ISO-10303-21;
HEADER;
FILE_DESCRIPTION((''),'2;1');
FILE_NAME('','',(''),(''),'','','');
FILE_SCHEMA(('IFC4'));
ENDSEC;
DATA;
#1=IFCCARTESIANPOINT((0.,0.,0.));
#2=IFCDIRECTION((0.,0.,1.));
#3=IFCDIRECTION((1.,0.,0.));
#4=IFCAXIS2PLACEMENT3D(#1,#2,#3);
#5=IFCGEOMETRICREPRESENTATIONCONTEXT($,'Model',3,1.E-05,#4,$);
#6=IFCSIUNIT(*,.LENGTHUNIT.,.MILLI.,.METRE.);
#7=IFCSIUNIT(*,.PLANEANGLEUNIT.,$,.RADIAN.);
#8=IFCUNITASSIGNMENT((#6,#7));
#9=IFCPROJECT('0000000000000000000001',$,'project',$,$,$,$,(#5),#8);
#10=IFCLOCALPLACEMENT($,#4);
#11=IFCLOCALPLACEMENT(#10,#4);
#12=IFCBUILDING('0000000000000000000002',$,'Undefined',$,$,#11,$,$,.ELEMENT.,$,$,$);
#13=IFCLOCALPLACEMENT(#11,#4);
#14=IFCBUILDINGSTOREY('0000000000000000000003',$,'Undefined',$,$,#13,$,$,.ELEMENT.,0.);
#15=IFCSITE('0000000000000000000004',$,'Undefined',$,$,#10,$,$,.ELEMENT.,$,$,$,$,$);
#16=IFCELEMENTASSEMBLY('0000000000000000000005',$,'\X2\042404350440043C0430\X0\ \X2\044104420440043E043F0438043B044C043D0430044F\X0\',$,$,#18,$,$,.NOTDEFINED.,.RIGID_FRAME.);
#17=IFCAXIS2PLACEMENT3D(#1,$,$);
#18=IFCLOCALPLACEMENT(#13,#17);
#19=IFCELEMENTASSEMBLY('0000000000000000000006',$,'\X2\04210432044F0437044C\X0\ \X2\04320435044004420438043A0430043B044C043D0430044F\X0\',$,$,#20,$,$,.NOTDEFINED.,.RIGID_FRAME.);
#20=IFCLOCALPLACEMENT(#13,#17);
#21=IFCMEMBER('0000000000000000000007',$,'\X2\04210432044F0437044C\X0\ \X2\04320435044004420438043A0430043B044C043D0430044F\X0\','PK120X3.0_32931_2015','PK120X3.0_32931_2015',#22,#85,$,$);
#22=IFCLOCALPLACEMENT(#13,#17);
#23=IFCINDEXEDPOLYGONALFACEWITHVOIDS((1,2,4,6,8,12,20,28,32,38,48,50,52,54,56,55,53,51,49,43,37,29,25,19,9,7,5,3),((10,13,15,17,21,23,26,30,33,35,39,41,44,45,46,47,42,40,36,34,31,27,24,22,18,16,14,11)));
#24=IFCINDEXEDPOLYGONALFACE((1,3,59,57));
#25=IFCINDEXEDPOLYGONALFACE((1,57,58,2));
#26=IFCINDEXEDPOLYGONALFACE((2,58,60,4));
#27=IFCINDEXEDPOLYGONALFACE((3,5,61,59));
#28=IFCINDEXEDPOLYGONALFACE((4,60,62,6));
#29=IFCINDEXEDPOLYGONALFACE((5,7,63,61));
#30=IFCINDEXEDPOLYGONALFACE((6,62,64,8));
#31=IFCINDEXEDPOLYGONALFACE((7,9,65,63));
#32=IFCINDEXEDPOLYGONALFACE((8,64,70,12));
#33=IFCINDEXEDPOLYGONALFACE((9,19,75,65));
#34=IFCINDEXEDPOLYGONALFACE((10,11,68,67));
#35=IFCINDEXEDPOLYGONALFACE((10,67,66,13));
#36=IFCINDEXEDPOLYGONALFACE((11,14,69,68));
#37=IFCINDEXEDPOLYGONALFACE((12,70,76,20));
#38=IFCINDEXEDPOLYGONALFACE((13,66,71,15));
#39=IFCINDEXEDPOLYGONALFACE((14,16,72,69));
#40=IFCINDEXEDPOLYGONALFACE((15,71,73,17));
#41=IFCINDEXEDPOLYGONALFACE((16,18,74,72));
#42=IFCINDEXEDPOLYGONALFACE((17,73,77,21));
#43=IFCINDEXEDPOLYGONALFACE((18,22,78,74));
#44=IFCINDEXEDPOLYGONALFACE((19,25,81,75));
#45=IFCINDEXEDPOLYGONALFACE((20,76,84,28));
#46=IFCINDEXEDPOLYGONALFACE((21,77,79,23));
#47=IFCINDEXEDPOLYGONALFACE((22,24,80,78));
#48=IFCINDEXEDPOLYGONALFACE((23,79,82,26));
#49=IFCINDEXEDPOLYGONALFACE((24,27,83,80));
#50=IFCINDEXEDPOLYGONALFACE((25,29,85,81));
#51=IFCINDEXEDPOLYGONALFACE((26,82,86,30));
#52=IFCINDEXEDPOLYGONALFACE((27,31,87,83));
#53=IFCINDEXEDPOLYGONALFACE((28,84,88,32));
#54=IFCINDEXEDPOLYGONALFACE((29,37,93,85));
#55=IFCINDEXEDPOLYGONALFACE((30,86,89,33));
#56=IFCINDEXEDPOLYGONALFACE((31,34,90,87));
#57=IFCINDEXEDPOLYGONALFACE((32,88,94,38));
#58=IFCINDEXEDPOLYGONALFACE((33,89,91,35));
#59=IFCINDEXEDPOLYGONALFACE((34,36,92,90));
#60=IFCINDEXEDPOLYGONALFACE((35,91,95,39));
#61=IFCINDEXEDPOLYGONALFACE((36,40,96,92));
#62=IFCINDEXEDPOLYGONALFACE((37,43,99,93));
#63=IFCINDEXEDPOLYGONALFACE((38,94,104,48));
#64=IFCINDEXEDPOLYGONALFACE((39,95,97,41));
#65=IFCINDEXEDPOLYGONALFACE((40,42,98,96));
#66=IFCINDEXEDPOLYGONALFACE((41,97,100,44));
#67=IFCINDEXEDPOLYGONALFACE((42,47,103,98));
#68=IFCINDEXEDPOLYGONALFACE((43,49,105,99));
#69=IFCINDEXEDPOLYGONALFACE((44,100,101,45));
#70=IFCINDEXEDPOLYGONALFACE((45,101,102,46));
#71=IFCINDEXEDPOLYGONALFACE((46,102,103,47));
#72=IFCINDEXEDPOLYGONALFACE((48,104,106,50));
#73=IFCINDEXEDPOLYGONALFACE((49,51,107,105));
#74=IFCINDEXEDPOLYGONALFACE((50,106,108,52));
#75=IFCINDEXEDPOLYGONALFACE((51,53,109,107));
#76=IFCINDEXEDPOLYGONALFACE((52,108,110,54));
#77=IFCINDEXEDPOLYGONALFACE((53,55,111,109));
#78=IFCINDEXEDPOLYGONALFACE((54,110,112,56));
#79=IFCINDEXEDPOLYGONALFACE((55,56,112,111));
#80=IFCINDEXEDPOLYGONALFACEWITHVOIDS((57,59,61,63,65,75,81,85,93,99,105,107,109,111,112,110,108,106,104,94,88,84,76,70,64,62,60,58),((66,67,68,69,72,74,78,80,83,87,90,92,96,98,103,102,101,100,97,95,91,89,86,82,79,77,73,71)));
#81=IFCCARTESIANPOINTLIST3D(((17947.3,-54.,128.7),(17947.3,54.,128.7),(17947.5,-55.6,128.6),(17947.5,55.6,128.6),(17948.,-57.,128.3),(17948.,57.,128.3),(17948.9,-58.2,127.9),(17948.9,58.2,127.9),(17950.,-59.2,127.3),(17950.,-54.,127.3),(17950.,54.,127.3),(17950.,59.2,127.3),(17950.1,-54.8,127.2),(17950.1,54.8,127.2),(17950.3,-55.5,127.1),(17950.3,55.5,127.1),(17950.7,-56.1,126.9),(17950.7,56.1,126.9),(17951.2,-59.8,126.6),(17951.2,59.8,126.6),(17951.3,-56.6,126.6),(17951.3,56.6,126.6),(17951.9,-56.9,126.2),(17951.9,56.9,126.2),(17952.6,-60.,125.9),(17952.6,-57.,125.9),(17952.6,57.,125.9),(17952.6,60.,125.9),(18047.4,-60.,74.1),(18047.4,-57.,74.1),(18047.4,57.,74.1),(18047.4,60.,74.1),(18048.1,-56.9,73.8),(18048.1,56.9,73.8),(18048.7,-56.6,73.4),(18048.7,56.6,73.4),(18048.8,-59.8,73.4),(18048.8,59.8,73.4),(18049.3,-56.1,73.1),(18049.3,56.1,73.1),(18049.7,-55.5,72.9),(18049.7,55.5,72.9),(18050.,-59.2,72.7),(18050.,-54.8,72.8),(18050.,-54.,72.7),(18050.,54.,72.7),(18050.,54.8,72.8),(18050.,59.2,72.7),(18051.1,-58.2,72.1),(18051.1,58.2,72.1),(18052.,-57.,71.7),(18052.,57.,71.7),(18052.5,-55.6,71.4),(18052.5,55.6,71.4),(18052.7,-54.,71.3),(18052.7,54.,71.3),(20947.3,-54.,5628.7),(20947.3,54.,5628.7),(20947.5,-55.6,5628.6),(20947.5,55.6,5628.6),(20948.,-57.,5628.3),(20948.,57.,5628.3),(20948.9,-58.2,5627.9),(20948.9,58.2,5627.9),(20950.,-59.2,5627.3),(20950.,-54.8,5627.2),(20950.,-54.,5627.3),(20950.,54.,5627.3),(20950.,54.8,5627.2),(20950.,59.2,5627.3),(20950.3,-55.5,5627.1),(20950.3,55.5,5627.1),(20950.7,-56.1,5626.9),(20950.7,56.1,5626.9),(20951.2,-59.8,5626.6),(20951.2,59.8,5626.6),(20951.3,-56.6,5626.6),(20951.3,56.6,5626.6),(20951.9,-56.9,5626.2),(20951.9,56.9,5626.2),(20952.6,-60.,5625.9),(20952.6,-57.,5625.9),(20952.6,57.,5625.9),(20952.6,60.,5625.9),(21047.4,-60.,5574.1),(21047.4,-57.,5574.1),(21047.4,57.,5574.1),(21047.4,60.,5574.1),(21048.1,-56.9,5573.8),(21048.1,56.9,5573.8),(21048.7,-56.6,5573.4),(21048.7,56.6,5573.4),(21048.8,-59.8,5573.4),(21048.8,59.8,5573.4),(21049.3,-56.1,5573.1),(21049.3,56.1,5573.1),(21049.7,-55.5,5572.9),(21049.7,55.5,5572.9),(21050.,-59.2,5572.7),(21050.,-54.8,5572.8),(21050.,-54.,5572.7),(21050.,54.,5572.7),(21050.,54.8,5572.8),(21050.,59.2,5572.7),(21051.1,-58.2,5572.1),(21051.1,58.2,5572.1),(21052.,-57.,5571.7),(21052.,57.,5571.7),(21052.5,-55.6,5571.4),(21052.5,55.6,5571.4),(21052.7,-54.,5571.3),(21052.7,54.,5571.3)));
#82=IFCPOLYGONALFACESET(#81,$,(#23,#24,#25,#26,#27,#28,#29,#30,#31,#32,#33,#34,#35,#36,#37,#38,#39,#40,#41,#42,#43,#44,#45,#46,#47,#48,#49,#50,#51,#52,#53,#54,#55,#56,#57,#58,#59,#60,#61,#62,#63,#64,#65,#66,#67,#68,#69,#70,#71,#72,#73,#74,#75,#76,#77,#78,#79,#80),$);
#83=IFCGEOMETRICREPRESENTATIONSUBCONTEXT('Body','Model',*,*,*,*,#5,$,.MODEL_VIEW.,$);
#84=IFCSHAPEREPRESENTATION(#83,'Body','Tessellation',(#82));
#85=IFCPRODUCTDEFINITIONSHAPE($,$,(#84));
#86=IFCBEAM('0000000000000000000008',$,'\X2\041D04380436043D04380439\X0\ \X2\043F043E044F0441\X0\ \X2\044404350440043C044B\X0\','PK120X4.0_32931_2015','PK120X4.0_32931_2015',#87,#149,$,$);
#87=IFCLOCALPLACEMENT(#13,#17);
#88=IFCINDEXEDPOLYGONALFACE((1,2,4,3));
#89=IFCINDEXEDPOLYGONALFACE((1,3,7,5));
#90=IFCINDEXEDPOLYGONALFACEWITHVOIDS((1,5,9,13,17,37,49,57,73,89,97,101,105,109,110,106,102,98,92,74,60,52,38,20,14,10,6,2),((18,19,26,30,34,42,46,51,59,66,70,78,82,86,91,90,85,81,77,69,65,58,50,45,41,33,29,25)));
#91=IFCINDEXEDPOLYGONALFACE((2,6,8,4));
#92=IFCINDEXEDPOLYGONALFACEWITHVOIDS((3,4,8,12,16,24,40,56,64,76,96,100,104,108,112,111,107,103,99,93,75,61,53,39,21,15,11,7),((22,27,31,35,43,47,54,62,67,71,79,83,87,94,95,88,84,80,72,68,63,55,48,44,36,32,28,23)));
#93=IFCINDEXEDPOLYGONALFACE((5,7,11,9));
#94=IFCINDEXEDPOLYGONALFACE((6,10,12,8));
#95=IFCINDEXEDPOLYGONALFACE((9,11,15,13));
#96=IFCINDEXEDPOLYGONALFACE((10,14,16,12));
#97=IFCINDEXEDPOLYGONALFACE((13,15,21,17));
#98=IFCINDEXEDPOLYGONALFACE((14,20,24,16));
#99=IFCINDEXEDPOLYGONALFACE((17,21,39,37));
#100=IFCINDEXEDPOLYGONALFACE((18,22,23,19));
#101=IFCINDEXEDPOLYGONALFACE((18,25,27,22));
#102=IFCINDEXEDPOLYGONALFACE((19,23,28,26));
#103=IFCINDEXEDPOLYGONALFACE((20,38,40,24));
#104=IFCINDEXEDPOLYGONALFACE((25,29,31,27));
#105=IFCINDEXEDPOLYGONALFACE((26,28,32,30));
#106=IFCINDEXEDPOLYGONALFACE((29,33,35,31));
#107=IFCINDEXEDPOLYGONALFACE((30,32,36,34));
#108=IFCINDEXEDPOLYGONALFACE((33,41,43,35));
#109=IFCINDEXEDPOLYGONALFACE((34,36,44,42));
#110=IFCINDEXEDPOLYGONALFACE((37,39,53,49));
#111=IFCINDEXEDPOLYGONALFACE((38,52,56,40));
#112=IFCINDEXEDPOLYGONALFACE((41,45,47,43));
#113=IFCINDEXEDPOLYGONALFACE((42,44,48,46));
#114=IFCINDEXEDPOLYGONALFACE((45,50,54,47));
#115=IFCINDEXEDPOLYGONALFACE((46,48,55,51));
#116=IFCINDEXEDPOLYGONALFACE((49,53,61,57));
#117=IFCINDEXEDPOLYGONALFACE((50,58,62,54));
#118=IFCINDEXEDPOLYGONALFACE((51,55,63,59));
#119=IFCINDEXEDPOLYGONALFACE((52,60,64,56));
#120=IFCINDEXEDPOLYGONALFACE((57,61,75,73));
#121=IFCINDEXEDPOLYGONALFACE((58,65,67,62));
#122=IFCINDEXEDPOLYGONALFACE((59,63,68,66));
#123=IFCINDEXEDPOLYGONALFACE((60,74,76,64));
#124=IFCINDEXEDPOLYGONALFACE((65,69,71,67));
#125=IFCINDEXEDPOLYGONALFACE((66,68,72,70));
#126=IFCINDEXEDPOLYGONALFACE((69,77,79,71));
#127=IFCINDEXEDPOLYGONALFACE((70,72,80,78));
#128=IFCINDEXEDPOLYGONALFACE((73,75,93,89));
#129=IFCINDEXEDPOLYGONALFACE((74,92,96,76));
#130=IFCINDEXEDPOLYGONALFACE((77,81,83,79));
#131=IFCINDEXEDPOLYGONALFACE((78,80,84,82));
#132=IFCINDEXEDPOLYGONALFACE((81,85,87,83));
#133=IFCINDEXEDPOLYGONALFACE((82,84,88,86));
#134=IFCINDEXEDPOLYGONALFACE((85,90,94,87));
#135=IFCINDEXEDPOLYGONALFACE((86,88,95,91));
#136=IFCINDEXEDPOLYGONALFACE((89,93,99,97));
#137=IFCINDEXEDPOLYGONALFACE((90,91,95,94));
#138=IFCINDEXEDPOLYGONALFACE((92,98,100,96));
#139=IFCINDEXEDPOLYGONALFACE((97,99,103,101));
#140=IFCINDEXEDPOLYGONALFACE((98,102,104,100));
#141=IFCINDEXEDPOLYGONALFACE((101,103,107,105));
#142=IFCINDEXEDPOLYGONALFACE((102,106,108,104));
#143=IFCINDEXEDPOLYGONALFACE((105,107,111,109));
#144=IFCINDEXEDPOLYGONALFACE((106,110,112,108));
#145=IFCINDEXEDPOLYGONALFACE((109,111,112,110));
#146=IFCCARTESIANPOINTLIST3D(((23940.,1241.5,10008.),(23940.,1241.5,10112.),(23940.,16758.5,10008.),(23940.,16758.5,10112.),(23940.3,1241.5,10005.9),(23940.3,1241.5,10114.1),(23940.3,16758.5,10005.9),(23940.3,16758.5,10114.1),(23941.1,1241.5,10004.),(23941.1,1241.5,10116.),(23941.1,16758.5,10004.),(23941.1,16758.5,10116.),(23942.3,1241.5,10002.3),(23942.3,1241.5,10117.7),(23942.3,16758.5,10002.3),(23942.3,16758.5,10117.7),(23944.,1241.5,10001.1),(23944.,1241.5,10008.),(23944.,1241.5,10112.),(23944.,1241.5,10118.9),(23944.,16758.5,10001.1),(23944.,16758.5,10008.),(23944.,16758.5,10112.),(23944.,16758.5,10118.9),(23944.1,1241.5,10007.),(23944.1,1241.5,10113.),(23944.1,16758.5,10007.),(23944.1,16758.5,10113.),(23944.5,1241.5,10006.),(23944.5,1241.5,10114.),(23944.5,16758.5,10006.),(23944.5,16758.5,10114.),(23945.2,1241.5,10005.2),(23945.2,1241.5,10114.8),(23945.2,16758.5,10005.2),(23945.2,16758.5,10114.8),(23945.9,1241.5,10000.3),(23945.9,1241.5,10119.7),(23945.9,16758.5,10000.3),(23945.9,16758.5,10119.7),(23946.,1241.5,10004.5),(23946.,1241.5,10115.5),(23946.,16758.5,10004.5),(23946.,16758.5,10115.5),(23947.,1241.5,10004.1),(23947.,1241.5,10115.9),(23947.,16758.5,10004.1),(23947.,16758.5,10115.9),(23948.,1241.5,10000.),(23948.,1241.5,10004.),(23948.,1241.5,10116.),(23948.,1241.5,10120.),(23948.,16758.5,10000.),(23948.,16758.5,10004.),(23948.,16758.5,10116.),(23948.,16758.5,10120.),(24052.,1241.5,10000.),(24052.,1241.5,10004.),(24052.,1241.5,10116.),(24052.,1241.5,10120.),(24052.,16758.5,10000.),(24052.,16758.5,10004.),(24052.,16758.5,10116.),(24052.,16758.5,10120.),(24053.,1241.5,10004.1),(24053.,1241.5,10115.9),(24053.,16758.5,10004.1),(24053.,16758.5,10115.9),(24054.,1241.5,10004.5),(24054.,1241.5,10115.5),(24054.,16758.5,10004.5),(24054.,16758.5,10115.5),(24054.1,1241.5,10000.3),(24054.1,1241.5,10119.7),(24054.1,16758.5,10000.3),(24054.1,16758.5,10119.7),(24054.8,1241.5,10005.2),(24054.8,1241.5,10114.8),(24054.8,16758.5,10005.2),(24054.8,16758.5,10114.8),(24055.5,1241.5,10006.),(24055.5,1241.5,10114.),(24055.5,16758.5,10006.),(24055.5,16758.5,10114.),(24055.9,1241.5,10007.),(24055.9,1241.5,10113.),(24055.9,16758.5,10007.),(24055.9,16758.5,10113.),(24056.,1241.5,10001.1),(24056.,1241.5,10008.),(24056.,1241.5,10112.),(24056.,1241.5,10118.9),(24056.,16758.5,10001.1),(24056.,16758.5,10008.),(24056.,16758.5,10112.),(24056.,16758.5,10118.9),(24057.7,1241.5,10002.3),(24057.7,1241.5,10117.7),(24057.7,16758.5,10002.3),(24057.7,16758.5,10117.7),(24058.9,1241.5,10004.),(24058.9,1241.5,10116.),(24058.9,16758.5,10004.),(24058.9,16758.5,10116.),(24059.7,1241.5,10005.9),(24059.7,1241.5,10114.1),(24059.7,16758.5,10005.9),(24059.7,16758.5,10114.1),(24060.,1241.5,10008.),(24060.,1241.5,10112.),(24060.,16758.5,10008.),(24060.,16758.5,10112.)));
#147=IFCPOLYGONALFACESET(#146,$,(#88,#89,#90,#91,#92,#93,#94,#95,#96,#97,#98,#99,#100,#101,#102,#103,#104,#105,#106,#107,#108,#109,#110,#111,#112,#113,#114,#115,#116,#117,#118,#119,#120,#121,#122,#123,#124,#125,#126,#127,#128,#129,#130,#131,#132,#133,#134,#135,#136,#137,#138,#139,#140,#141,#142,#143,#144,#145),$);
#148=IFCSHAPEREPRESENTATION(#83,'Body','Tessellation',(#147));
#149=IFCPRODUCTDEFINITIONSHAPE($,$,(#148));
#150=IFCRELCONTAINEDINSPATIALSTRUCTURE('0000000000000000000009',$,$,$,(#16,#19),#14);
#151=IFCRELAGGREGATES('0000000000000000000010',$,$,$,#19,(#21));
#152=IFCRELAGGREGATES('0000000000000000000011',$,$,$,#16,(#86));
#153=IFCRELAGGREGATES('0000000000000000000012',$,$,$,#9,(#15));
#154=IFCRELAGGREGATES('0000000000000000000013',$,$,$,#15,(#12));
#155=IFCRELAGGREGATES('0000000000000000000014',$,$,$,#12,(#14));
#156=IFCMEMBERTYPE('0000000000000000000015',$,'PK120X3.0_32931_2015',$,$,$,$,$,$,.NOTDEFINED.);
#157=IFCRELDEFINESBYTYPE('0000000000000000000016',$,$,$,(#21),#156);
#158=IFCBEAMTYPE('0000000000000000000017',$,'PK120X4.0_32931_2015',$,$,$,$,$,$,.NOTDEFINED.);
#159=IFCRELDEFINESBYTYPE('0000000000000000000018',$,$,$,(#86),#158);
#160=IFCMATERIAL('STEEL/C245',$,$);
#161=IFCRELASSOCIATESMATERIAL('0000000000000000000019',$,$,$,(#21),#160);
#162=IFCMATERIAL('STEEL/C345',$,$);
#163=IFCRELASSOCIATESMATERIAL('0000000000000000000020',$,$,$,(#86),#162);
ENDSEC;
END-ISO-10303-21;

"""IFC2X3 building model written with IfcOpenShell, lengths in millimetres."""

from ifc_helpers import new_model, si_unit, frame, origin_with_axes, origin_2d_with_axis, place, context, subcontext, project, spatial, hollow_rectangle, extrude, material, type_object, element, aggregate, save


model = new_model("IFC2X3")

# Units and contexts
model_context = context("Model", 3, precision=1e-05, world=origin_with_axes())
body_context = subcontext(model_context, "Body", "Model", "MODEL_VIEW")
ifc_project = project(units=[si_unit("LENGTHUNIT", "METRE", prefix="MILLI"), si_unit("PLANEANGLEUNIT", "RADIAN")], contexts=[model_context])

# Site, building, storey
site_placement = place(None, origin_with_axes())
site = spatial("IfcSite", under=ifc_project, at=site_placement, Name="Undefined", CompositionType="ELEMENT")
building_placement = place(site_placement, origin_with_axes())
building = spatial("IfcBuilding", under=site, at=building_placement, Name="Undefined", CompositionType="ELEMENT")
storey_placement = place(building_placement, origin_with_axes())
storey = spatial("IfcBuildingStorey", under=building, at=storey_placement, Name="Undefined", CompositionType="ELEMENT", Elevation=0.0)

# Shared definitions
ifc_material_1 = material(Name="STEEL/C245")

# Element assemblies, member
member_type_1 = type_object("IfcMemberType", Name="PK120X3.0_32931_2015", PredefinedType="NOTDEFINED")
assembly_1_placement = place(storey_placement, origin_with_axes())
assembly_1 = element("IfcElementAssembly", 1, at=assembly_1_placement, inside=storey, Name="Ферма стропильная", AssemblyPlace="NOTDEFINED", PredefinedType="RIGID_FRAME")
assembly_2_placement = place(storey_placement, origin_with_axes())
assembly_2 = element("IfcElementAssembly", 2, at=assembly_2_placement, inside=storey, Name="Связь вертикальная", AssemblyPlace="NOTDEFINED", PredefinedType="RIGID_FRAME")
member_1_placement = place(assembly_2_placement, frame((18000.0, 0.0, 100.0), z_axis=(-0.877896, 0.0, 0.478852), x_axis=(0.478852, 0.0, 0.877896)))
member_1 = element("IfcMember", 3, at=member_1_placement, type_object=member_type_1, material=ifc_material_1, Name="Связь вертикальная", Description="PK120X3.0_32931_2015", ObjectType="PK120X3.0_32931_2015", context=body_context, shape_type="SweptSolid", body=[
    extrude(hollow_rectangle(XDim=120.0, YDim=120.0, WallThickness=3.0, InnerFilletRadius=3.0, OuterFilletRadius=6.0, at=origin_2d_with_axis()), frame((6265.0, 0.0, 0.0), z_axis=(-1.0, 0.0, 0.0), x_axis=(0.0, -1.0, 0.0)), (0.0, 0.0, 1.0), 6265.0),
])
aggregate(assembly_2, [member_1])

# Beam
ifc_material_2 = material(Name="STEEL/C345")
beam_type_1 = type_object("IfcBeamType", Name="PK120X4.0_32931_2015", PredefinedType="NOTDEFINED")
beam_1_placement = place(assembly_1_placement, frame((24000.0, 1241.5, 10060.0), z_axis=(0.0, 0.0, 1.0), x_axis=(0.0, 1.0, 0.0)))
beam_1 = element("IfcBeam", 4, at=beam_1_placement, type_object=beam_type_1, material=ifc_material_2, Name="Нижний пояс фермы", Description="PK120X4.0_32931_2015", ObjectType="PK120X4.0_32931_2015", context=body_context, shape_type="SweptSolid", body=[
    extrude(hollow_rectangle(XDim=120.0, YDim=120.0, WallThickness=4.0, InnerFilletRadius=4.0, OuterFilletRadius=8.0, at=origin_2d_with_axis()), frame((15517.0, 0.0, 0.0), z_axis=(-1.0, 0.0, 0.0), x_axis=(0.0, -1.0, 0.0)), (0.0, 0.0, 1.0), 15517.0),
])
aggregate(assembly_1, [beam_1])

save(model, "model.ifc")
